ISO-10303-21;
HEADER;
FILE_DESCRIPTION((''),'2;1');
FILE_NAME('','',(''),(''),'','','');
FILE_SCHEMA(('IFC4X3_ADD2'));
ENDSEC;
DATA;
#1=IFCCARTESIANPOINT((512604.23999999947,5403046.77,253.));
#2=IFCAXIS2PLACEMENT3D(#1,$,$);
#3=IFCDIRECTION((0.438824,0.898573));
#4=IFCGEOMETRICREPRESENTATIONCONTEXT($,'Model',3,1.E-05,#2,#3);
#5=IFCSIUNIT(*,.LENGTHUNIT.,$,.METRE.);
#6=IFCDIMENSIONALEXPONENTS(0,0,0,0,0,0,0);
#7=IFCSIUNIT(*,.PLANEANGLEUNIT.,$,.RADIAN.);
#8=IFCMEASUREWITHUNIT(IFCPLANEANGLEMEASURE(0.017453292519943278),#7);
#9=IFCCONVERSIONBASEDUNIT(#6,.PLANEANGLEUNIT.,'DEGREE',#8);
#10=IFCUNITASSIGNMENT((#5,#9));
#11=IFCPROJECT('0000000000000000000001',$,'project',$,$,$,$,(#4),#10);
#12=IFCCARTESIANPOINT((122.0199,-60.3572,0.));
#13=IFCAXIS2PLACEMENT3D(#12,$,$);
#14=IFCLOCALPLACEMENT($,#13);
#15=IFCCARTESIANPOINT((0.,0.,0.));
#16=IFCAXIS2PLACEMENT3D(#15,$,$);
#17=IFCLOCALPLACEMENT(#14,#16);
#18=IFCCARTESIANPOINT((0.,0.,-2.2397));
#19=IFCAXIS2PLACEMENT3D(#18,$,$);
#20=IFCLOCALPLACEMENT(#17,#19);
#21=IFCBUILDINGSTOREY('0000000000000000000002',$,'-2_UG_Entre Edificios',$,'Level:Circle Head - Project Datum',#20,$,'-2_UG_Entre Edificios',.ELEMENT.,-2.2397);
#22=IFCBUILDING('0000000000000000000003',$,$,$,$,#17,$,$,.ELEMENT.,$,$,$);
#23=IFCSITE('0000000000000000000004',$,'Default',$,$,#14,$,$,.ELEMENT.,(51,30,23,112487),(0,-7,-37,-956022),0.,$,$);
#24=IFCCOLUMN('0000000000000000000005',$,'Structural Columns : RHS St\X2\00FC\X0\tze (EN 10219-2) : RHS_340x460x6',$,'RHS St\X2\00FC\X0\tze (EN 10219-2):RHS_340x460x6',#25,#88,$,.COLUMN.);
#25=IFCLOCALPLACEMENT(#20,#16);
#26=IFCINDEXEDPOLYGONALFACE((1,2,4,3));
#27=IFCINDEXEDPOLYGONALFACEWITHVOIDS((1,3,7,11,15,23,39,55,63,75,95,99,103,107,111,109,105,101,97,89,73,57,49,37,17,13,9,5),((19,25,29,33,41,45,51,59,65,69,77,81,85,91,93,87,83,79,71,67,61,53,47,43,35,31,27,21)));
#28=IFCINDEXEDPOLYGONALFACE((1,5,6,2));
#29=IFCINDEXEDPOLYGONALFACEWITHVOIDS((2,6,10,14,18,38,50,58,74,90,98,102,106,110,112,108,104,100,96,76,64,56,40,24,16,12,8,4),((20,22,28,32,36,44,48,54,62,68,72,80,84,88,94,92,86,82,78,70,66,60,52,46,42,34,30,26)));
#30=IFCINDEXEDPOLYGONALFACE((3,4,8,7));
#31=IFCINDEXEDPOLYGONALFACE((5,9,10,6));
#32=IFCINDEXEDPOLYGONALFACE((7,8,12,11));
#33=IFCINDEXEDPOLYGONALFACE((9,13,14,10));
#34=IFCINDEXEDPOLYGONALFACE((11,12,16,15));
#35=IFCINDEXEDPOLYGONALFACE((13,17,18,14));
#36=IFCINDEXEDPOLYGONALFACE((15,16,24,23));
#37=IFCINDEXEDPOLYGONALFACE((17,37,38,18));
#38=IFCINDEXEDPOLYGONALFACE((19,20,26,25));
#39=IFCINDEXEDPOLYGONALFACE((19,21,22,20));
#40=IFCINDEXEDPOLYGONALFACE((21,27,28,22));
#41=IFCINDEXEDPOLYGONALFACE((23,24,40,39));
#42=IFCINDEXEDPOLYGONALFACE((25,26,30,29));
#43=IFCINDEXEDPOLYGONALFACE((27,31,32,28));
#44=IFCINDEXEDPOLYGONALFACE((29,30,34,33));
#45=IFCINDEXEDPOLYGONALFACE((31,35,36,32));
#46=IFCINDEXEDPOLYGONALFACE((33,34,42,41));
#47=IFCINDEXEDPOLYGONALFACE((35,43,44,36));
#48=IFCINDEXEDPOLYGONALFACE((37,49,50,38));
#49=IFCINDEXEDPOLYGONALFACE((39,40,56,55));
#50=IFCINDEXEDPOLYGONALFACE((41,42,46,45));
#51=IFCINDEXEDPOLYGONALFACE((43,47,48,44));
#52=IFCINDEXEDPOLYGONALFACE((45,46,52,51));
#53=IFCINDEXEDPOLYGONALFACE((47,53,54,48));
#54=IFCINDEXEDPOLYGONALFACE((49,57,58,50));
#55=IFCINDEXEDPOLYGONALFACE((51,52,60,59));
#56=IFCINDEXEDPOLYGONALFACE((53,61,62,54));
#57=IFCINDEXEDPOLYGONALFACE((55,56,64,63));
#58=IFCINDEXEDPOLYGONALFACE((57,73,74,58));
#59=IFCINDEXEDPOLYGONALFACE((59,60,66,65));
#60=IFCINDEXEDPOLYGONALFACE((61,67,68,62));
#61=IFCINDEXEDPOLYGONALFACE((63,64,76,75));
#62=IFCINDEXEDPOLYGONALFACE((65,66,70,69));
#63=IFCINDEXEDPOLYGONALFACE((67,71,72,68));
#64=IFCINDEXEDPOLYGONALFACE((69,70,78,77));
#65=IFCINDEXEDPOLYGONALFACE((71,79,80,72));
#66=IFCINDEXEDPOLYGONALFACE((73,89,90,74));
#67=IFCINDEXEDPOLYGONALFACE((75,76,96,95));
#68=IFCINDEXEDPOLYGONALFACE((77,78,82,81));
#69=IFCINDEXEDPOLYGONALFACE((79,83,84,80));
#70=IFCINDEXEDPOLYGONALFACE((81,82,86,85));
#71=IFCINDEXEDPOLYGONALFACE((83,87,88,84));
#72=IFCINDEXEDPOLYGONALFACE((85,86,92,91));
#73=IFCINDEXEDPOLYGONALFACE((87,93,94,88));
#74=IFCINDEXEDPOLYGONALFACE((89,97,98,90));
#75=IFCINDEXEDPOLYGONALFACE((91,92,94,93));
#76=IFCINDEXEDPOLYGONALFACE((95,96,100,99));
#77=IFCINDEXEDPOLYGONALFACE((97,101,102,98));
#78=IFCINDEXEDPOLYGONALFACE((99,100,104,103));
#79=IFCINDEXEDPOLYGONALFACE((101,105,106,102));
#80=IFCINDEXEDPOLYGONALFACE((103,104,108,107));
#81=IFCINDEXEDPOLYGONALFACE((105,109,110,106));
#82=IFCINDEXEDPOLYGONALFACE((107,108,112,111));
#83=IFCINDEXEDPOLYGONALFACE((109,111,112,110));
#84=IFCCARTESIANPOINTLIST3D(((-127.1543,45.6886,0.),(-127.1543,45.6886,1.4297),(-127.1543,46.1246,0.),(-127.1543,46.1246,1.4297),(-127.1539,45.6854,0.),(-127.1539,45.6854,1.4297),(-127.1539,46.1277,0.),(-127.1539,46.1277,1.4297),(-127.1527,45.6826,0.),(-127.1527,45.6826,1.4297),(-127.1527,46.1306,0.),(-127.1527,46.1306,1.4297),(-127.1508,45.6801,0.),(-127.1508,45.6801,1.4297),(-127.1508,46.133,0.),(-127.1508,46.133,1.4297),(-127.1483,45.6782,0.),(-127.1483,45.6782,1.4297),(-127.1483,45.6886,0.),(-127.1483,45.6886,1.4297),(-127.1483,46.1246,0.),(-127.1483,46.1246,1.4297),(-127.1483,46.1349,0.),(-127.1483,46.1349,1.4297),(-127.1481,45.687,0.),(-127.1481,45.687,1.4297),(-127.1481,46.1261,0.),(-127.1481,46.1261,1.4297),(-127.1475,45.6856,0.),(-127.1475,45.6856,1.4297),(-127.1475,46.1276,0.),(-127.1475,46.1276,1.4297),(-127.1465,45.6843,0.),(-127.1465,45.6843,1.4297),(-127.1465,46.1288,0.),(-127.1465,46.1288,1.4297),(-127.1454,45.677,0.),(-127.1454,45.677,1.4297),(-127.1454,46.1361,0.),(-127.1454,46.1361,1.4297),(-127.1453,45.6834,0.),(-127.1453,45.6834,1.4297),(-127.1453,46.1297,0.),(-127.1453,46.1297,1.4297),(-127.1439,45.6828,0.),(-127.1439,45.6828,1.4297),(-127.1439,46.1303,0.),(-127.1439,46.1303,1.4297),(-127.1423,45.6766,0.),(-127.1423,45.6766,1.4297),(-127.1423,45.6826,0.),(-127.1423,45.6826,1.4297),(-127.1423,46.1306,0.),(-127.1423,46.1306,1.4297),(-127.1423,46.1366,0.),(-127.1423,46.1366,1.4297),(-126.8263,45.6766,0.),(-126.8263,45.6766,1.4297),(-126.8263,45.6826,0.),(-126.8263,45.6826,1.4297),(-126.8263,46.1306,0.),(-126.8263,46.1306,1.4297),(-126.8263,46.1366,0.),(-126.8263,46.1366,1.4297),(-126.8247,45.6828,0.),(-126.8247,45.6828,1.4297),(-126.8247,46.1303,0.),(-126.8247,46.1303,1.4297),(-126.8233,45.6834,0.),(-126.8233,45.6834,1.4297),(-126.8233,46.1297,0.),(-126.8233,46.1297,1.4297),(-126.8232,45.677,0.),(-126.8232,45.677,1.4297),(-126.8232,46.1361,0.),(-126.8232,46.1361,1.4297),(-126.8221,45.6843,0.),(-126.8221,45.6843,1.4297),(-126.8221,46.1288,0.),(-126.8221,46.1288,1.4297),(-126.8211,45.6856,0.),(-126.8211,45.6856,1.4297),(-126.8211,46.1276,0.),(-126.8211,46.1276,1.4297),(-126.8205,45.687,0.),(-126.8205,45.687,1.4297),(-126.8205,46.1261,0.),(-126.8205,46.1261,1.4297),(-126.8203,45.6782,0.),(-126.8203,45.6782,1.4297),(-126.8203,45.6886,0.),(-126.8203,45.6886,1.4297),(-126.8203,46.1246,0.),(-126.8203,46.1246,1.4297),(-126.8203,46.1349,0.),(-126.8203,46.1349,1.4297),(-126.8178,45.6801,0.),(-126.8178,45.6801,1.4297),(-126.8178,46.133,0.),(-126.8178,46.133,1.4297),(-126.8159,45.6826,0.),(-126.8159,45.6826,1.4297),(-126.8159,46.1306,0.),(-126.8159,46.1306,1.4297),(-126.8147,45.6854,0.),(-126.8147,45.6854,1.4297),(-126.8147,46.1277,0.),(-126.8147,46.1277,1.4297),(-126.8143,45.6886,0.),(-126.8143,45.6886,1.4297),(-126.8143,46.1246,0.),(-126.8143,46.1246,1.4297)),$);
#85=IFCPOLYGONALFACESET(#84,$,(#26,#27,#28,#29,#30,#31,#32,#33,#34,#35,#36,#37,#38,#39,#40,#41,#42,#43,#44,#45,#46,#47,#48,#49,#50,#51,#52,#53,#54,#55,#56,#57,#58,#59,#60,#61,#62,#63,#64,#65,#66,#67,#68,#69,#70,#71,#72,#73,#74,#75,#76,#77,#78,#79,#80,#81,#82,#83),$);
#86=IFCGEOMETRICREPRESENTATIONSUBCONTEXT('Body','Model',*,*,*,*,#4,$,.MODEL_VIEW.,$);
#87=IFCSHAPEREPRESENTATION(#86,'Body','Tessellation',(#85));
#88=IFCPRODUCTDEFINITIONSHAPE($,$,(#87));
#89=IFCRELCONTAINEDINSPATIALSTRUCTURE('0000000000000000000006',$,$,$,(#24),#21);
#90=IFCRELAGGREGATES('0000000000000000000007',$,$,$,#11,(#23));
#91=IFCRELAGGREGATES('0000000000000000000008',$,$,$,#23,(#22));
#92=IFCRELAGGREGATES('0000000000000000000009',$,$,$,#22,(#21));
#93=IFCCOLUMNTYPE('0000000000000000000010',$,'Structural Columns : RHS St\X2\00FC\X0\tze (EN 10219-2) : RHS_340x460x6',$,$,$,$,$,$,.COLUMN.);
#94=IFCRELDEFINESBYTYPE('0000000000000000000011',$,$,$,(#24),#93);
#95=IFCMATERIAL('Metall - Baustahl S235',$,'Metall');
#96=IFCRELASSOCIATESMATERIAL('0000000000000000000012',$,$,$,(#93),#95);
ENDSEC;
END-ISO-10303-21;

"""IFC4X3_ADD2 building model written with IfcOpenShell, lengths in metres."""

from ifc_helpers import new_model, entity, si_unit, converted_unit, direction, frame, frame_2d, origin, place, context, subcontext, project, spatial, polyline, circle_curve, parameter, trimmed, segment, composite_curve, outline, extrude, source, transform, mapped, material, material_profile, profile_set, type_object, type_shapes, element, save


model = new_model("IFC4X3_ADD2")

# Units and contexts
model_context = context("Model", 3, precision=1e-05, world=frame((512604.23999999947, 5403046.77, 253.0)), true_north=direction((0.438824, 0.898573)))
body_context = subcontext(model_context, "Body", "Model", "MODEL_VIEW")
ifc_project = project(units=[si_unit("LENGTHUNIT", "METRE"), converted_unit("PLANEANGLEUNIT", "DEGREE", entity("IfcPlaneAngleMeasure", 0.017453292519943278), si_unit("PLANEANGLEUNIT", "RADIAN"), dimensions=[0, 0, 0, 0, 0, 0, 0])], contexts=[model_context])

# Site, building, storey
site_placement = place(None, frame((122.0199, -60.3572, 0.0)))
site = spatial("IfcSite", under=ifc_project, at=site_placement, Name="Default", CompositionType="ELEMENT", RefLatitude=(51, 30, 23, 112487), RefLongitude=(0, -7, -37, -956022), RefElevation=0.0)
building_placement = place(site_placement, origin())
building = spatial("IfcBuilding", under=site, at=building_placement, CompositionType="ELEMENT")
storey_placement = place(building_placement, frame((0.0, 0.0, -2.2397)))
storey = spatial("IfcBuildingStorey", under=building, at=storey_placement, Name="-2_UG_Entre Edificios", ObjectType="Level:Circle Head - Project Datum", LongName="-2_UG_Entre Edificios", CompositionType="ELEMENT", Elevation=-2.2397)

# Column
ifc_material_1 = material(Name="Metall - Baustahl S235", Category="Metall")
ifc_material_profile_1 = material_profile(ifc_material_1, outline(composite_curve([segment(polyline([(-0.158, -0.23), (0.158, -0.23)]), True, "CONTINUOUS"), segment(trimmed(circle_curve(frame_2d((0.158, -0.218), x_axis=(-1.0, 0.0)), 0.012), [parameter(90.0)], [parameter(180.0)], True, "PARAMETER"), True, "CONTINUOUS"), segment(polyline([(0.17, -0.218), (0.17, 0.218)]), True, "CONTINUOUS"), segment(trimmed(circle_curve(frame_2d((0.158, 0.218), x_axis=(-1.0, 0.0)), 0.012), [parameter(180.0)], [parameter(270.0)], True, "PARAMETER"), True, "CONTINUOUS"), segment(polyline([(0.158, 0.23), (-0.158, 0.23)]), True, "CONTINUOUS"), segment(trimmed(circle_curve(frame_2d((-0.158, 0.218), x_axis=(-1.0, 0.0)), 0.012), [parameter(270.0)], [parameter(360.0)], True, "PARAMETER"), True, "CONTINUOUS"), segment(polyline([(-0.17, 0.218), (-0.17, -0.218)]), True, "CONTINUOUS"), segment(trimmed(circle_curve(frame_2d((-0.158, -0.218), x_axis=(-1.0, 0.0)), 0.012), [parameter(360.0)], [parameter(90.0)], True, "PARAMETER"), True, "CONTINUOUS")], self_intersect=False), holes=[composite_curve([segment(trimmed(circle_curve(frame_2d((-0.158, -0.218), x_axis=(-1.0, 0.0)), 0.006), [parameter(0.0)], [parameter(90.0)], True, "PARAMETER"), False, "CONTINUOUS"), segment(polyline([(-0.164, -0.218), (-0.164, 0.218)]), True, "CONTINUOUS"), segment(trimmed(circle_curve(frame_2d((-0.158, 0.218), x_axis=(-1.0, 0.0)), 0.006), [parameter(270.0)], [parameter(360.0)], True, "PARAMETER"), False, "CONTINUOUS"), segment(polyline([(-0.158, 0.224), (0.158, 0.224)]), True, "CONTINUOUS"), segment(trimmed(circle_curve(frame_2d((0.158, 0.218), x_axis=(-1.0, 0.0)), 0.006), [parameter(180.0)], [parameter(270.0)], True, "PARAMETER"), False, "CONTINUOUS"), segment(polyline([(0.164, 0.218), (0.164, -0.218)]), True, "CONTINUOUS"), segment(trimmed(circle_curve(frame_2d((0.158, -0.218), x_axis=(-1.0, 0.0)), 0.006), [parameter(90.0)], [parameter(180.0)], True, "PARAMETER"), False, "CONTINUOUS"), segment(polyline([(0.158, -0.224), (-0.158, -0.224)]), True, "CONTINUOUS")], self_intersect=False)]), Name="RHS_340x460x6")
ifc_profile_set_1 = profile_set([ifc_material_profile_1], Name="RHS_340x460x6")
column_type_1 = type_object("IfcColumnType", Name="Structural Columns : RHS Stütze (EN 10219-2) : RHS_340x460x6", PredefinedType="COLUMN", material=ifc_profile_set_1)
shared_shape_1 = source(origin(), body_context, "Body", "SweptSolid", [
    extrude(outline(composite_curve([segment(polyline([(-0.158, -0.23), (0.158, -0.23)]), True, "CONTINUOUS"), segment(trimmed(circle_curve(frame_2d((0.158, -0.218), x_axis=(-1.0, 0.0)), 0.012), [parameter(90.0)], [parameter(180.0)], True, "PARAMETER"), True, "CONTINUOUS"), segment(polyline([(0.17, -0.218), (0.17, 0.218)]), True, "CONTINUOUS"), segment(trimmed(circle_curve(frame_2d((0.158, 0.218), x_axis=(-1.0, 0.0)), 0.012), [parameter(180.0)], [parameter(270.0)], True, "PARAMETER"), True, "CONTINUOUS"), segment(polyline([(0.158, 0.23), (-0.158, 0.23)]), True, "CONTINUOUS"), segment(trimmed(circle_curve(frame_2d((-0.158, 0.218), x_axis=(-1.0, 0.0)), 0.012), [parameter(270.0)], [parameter(360.0)], True, "PARAMETER"), True, "CONTINUOUS"), segment(polyline([(-0.17, 0.218), (-0.17, -0.218)]), True, "CONTINUOUS"), segment(trimmed(circle_curve(frame_2d((-0.158, -0.218), x_axis=(-1.0, 0.0)), 0.012), [parameter(360.0)], [parameter(90.0)], True, "PARAMETER"), True, "CONTINUOUS")], self_intersect=False), holes=[composite_curve([segment(trimmed(circle_curve(frame_2d((-0.158, -0.218), x_axis=(-1.0, 0.0)), 0.006), [parameter(0.0)], [parameter(90.0)], True, "PARAMETER"), False, "CONTINUOUS"), segment(polyline([(-0.164, -0.218), (-0.164, 0.218)]), True, "CONTINUOUS"), segment(trimmed(circle_curve(frame_2d((-0.158, 0.218), x_axis=(-1.0, 0.0)), 0.006), [parameter(270.0)], [parameter(360.0)], True, "PARAMETER"), False, "CONTINUOUS"), segment(polyline([(-0.158, 0.224), (0.158, 0.224)]), True, "CONTINUOUS"), segment(trimmed(circle_curve(frame_2d((0.158, 0.218), x_axis=(-1.0, 0.0)), 0.006), [parameter(180.0)], [parameter(270.0)], True, "PARAMETER"), False, "CONTINUOUS"), segment(polyline([(0.164, 0.218), (0.164, -0.218)]), True, "CONTINUOUS"), segment(trimmed(circle_curve(frame_2d((0.158, -0.218), x_axis=(-1.0, 0.0)), 0.006), [parameter(90.0)], [parameter(180.0)], True, "PARAMETER"), False, "CONTINUOUS"), segment(polyline([(0.158, -0.224), (-0.158, -0.224)]), True, "CONTINUOUS")], self_intersect=False)]), frame((0.0, 0.0, -2.2397), z_axis=(0.0, 0.0, 1.0), x_axis=(-1.0, 0.0, 0.0)), (0.0, 0.0, 1.0), 1.4297),
])
type_shapes(column_type_1, [shared_shape_1])
column_1_placement = place(storey_placement, frame((-126.9843, 45.9066, 2.2397)))
element("IfcColumn", 1, at=column_1_placement, inside=storey, type_object=column_type_1, Name="Structural Columns : RHS Stütze (EN 10219-2) : RHS_340x460x6", ObjectType="RHS Stütze (EN 10219-2):RHS_340x460x6", PredefinedType="COLUMN", context=body_context, shape_type="MappedRepresentation", body=[
    mapped(shared_shape_1, transform((0.0, 0.0, 0.0), scale=1.0)),
])

save(model, "model.ifc")
